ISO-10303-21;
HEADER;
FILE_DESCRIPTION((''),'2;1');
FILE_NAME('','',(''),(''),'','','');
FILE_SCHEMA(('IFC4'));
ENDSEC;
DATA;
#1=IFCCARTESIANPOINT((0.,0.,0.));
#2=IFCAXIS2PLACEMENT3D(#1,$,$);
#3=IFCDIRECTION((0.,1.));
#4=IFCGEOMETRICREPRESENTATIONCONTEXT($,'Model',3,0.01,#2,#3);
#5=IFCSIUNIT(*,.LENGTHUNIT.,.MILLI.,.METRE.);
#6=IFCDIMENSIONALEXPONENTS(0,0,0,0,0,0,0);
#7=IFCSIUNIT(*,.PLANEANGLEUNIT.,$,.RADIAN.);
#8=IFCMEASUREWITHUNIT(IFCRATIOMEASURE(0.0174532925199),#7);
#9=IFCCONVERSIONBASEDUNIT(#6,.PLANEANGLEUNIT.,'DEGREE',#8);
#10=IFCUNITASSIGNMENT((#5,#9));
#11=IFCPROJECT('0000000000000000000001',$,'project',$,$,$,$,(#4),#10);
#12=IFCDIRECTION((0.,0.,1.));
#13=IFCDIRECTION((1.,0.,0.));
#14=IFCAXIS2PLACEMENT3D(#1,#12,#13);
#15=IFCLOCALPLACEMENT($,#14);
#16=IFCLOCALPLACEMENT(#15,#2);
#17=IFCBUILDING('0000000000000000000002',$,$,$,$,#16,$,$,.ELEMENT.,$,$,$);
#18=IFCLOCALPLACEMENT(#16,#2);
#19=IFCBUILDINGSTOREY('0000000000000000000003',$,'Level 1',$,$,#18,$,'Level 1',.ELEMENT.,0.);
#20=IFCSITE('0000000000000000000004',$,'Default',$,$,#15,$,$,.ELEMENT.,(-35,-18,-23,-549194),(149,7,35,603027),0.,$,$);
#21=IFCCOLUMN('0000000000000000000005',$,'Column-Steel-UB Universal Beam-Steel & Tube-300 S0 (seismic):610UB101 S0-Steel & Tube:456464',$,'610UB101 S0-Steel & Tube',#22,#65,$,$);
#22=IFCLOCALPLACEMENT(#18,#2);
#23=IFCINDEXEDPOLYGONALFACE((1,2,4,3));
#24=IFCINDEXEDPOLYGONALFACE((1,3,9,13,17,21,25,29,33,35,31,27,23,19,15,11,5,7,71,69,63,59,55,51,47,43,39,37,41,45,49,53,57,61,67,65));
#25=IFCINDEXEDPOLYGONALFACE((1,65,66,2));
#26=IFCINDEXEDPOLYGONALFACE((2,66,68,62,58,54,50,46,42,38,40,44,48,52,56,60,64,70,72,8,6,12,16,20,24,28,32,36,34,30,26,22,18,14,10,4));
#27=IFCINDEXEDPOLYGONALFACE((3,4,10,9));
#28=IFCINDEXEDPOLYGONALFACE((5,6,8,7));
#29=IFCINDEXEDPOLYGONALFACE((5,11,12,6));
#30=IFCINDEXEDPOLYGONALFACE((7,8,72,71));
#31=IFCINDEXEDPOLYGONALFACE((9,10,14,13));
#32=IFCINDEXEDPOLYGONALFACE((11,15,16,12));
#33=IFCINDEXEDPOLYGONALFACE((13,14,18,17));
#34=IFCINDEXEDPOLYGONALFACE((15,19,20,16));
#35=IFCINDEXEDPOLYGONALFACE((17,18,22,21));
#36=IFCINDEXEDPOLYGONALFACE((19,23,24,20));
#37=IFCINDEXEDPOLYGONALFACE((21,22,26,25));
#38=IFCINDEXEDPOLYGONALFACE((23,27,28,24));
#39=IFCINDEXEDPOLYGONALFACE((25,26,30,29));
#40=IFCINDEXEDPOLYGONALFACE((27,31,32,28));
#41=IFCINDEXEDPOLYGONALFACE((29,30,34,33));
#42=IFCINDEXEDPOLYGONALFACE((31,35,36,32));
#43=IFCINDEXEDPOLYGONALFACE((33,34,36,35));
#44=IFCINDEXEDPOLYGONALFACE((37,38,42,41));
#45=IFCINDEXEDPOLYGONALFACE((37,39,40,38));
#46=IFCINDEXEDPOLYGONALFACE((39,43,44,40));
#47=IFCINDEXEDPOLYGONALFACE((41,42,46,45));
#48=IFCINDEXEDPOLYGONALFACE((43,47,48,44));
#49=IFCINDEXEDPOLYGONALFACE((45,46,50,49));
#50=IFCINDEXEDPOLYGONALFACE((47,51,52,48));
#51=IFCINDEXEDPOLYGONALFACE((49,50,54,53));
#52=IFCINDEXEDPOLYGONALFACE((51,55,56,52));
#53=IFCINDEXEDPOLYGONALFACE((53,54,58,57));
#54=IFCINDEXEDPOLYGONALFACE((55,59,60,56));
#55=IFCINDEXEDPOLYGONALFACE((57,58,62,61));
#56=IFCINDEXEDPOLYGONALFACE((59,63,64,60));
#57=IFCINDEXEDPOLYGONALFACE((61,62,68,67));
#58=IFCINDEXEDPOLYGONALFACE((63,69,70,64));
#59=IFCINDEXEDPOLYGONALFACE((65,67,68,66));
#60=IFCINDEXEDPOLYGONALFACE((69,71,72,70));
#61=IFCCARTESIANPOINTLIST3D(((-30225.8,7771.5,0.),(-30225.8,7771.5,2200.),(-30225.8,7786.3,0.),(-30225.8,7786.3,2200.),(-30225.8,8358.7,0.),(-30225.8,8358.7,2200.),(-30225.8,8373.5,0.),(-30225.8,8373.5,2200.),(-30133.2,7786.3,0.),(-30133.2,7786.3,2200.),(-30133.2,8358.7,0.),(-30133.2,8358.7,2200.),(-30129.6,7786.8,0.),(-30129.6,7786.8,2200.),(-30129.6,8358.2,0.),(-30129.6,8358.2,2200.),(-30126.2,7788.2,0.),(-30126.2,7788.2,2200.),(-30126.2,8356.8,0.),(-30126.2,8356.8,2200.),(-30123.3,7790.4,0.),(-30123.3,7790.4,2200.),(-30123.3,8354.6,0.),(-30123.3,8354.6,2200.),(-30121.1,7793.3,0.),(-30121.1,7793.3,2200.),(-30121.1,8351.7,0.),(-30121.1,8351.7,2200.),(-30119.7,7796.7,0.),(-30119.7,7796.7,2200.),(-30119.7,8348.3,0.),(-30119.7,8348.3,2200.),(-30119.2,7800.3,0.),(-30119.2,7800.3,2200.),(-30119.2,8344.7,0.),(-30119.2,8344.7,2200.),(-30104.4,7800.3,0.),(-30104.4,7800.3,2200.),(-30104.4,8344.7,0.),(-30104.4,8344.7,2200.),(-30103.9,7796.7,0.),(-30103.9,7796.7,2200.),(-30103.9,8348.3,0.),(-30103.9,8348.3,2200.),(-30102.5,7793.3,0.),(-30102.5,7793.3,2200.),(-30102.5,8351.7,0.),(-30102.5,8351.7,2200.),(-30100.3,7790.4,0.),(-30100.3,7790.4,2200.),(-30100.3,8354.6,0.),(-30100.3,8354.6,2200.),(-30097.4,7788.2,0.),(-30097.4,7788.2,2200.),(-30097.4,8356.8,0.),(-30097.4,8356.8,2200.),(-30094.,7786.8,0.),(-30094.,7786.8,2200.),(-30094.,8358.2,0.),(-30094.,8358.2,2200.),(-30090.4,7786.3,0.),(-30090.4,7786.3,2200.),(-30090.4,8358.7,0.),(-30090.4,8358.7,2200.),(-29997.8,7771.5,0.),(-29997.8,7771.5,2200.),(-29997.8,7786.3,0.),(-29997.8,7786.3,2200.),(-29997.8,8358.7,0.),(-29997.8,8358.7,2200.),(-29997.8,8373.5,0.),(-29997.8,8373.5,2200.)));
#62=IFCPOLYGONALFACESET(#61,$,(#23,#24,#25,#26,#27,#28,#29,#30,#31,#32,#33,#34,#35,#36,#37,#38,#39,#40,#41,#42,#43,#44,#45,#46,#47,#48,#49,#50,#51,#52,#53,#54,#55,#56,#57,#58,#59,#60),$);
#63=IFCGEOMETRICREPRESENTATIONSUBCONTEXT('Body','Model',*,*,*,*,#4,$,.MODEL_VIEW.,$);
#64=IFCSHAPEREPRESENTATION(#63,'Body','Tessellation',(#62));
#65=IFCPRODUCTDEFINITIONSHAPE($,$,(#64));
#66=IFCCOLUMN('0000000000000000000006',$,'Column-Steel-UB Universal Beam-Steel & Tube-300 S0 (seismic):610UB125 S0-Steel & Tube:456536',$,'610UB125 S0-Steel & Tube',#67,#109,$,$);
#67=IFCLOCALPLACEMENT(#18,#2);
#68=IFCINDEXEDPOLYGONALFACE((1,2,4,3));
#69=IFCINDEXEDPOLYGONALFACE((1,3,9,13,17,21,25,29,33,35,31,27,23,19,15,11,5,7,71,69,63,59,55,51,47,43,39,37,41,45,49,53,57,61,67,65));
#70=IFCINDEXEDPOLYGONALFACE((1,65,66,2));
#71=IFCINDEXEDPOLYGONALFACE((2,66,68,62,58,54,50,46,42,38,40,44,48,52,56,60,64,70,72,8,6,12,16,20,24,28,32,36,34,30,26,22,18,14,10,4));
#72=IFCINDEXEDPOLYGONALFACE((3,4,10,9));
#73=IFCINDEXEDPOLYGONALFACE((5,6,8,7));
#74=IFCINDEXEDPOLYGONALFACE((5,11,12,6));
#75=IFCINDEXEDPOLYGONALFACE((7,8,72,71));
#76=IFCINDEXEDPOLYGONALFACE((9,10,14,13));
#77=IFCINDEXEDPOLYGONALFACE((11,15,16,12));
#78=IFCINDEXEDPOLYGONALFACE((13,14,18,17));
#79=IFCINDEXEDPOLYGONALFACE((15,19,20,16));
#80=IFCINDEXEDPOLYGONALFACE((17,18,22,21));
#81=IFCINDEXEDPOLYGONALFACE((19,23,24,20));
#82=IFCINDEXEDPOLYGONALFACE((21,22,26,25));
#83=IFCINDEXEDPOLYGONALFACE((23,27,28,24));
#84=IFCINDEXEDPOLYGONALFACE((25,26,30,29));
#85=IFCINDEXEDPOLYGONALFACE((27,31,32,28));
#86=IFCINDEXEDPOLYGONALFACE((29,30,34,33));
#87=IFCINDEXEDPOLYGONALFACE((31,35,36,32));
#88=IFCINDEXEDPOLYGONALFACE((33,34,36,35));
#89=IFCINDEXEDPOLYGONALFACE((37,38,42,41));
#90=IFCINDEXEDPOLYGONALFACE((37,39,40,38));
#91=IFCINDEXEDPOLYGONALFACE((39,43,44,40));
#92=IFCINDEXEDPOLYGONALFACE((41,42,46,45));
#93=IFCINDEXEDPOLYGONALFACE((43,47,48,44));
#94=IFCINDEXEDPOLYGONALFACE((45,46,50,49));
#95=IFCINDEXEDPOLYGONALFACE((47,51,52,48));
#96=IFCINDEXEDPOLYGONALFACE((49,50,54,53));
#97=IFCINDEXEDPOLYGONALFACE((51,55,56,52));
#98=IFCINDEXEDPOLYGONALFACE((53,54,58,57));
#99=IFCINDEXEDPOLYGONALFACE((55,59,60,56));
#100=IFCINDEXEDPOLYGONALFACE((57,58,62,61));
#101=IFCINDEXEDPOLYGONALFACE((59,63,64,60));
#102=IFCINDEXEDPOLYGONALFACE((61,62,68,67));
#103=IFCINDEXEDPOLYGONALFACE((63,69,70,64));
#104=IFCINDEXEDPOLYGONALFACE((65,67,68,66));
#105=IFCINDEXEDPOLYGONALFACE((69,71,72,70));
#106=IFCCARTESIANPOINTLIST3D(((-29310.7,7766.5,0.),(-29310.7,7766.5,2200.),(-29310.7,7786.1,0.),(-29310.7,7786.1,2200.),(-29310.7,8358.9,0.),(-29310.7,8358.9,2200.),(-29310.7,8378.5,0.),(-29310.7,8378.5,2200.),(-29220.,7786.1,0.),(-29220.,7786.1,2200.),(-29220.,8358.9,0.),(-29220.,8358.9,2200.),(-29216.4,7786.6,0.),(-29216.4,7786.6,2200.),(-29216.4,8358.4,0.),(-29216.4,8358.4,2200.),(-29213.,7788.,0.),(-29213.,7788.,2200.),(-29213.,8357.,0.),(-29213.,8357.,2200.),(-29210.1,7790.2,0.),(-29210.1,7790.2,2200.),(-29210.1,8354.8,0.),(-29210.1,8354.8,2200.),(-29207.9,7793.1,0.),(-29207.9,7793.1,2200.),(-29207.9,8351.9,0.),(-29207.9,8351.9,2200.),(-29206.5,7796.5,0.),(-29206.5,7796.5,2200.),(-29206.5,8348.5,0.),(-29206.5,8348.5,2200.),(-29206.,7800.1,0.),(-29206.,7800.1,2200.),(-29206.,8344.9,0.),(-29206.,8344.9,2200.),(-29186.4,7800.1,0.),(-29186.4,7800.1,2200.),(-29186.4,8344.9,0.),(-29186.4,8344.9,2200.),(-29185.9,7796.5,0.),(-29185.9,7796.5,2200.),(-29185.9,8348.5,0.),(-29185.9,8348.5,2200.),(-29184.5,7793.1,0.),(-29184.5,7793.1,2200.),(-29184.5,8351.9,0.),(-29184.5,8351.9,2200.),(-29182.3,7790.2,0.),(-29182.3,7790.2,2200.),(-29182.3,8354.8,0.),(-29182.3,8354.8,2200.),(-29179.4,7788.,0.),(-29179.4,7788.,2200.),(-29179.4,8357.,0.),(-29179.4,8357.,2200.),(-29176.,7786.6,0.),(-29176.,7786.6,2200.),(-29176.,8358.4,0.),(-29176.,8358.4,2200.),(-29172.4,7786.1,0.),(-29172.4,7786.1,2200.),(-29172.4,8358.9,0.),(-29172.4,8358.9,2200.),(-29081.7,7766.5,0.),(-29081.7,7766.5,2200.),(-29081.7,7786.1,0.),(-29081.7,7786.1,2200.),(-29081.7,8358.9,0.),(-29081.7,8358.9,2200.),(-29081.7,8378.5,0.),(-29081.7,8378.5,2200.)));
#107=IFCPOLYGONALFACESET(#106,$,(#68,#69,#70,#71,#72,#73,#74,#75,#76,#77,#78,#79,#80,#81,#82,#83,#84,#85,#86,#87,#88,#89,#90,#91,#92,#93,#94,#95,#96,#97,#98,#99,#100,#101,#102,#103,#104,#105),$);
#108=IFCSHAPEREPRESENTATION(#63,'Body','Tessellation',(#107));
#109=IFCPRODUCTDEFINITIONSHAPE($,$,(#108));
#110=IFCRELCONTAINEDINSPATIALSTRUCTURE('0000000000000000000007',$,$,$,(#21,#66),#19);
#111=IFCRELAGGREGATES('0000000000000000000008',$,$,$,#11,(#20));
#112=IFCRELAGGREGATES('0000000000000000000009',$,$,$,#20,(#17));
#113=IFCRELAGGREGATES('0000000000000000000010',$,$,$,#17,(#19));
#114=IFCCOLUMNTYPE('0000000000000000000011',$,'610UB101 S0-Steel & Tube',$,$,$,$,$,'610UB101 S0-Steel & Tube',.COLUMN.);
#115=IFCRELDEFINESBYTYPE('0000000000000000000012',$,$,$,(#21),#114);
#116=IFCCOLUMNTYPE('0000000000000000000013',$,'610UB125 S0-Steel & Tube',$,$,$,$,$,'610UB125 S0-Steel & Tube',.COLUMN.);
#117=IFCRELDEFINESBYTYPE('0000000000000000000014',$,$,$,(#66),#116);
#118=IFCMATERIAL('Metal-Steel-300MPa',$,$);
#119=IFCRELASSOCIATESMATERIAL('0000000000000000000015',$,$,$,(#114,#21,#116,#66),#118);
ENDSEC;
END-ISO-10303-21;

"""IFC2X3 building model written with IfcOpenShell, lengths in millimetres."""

from ifc_helpers import new_model, entity, si_unit, converted_unit, direction, frame, frame_2d, origin, origin_with_axes, place, context, subcontext, project, spatial, polyline, circle_curve, parameter, trimmed, segment, composite_curve, outline, extrude, source, transform, mapped, material, type_object, type_shapes, element, save


model = new_model("IFC2X3")

# Units and contexts
model_context = context("Model", 3, precision=0.01, world=origin(), true_north=direction((0.0, 1.0)))
body_context = subcontext(model_context, "Body", "Model", "MODEL_VIEW")
ifc_project = project(units=[si_unit("LENGTHUNIT", "METRE", prefix="MILLI"), converted_unit("PLANEANGLEUNIT", "DEGREE", entity("IfcRatioMeasure", 0.0174532925199), si_unit("PLANEANGLEUNIT", "RADIAN"), dimensions=[0, 0, 0, 0, 0, 0, 0])], contexts=[model_context])

# Site, building, storey
site_placement = place(None, origin_with_axes())
site = spatial("IfcSite", under=ifc_project, at=site_placement, Name="Default", CompositionType="ELEMENT", RefLatitude=(-35, -18, -23, -549194), RefLongitude=(149, 7, 35, 603027), RefElevation=0.0)
building_placement = place(site_placement, origin())
building = spatial("IfcBuilding", under=site, at=building_placement, CompositionType="ELEMENT")
storey_placement = place(building_placement, origin())
storey = spatial("IfcBuildingStorey", under=building, at=storey_placement, Name="Level 1", LongName="Level 1", CompositionType="ELEMENT", Elevation=0.0)

# Columns
ifc_material = material(Name="Metal-Steel-300MPa")
column_type_1 = type_object("IfcColumnType", Name="610UB101 S0-Steel & Tube", ElementType="610UB101 S0-Steel & Tube", PredefinedType="COLUMN", material=ifc_material)
shared_shape_1 = source(origin(), body_context, "Body", "SweptSolid", [
    extrude(outline(composite_curve([segment(polyline([(286.2, -114.0), (301.0, -114.0)]), True, "CONTINUOUS"), segment(polyline([(301.0, -114.0), (301.0, 114.0)]), True, "CONTINUOUS"), segment(polyline([(301.0, 114.0), (286.2, 114.0)]), True, "CONTINUOUS"), segment(polyline([(286.2, 114.0), (286.2, 21.4)]), True, "CONTINUOUS"), segment(trimmed(circle_curve(frame_2d((272.2, 21.4), x_axis=(1.0, 0.0)), 14.0), [parameter(270.0)], [parameter(0.0)], True, "PARAMETER"), False, "CONTINUOUS"), segment(polyline([(272.2, 7.4), (-272.2, 7.4)]), True, "CONTINUOUS"), segment(trimmed(circle_curve(frame_2d((-272.2, 21.4), x_axis=(0.0, -1.0)), 14.0), [parameter(270.0)], [parameter(0.0)], True, "PARAMETER"), False, "CONTINUOUS"), segment(polyline([(-286.2, 21.4), (-286.2, 114.0)]), True, "CONTINUOUS"), segment(polyline([(-286.2, 114.0), (-301.0, 114.0)]), True, "CONTINUOUS"), segment(polyline([(-301.0, 114.0), (-301.0, -114.0)]), True, "CONTINUOUS"), segment(polyline([(-301.0, -114.0), (-286.2, -114.0)]), True, "CONTINUOUS"), segment(polyline([(-286.2, -114.0), (-286.2, -21.4)]), True, "CONTINUOUS"), segment(trimmed(circle_curve(frame_2d((-272.2, -21.4), x_axis=(-1.0, 0.0)), 14.0), [parameter(270.0)], [parameter(0.0)], True, "PARAMETER"), False, "CONTINUOUS"), segment(polyline([(-272.2, -7.4), (272.2, -7.4)]), True, "CONTINUOUS"), segment(trimmed(circle_curve(frame_2d((272.2, -21.4), x_axis=(0.0, 1.0)), 14.0), [parameter(270.0)], [parameter(0.0)], True, "PARAMETER"), False, "CONTINUOUS"), segment(polyline([(286.2, -21.4), (286.2, -114.0)]), True, "CONTINUOUS")], self_intersect=False)), frame((0.0, 0.0, 0.0), z_axis=(0.0, 0.0, 1.0), x_axis=(0.0, -1.0, 0.0)), (0.0, 0.0, 1.0), 2200.0),
])
type_shapes(column_type_1, [shared_shape_1])
column_1_placement = place(storey_placement, frame((-30111.8, 8072.5, 0.0)))
element("IfcColumn", 1, at=column_1_placement, inside=storey, type_object=column_type_1, material=ifc_material, Name="Column-Steel-UB Universal Beam-Steel & Tube-300 S0 (seismic):610UB101 S0-Steel & Tube:456464", ObjectType="610UB101 S0-Steel & Tube", context=body_context, shape_type="MappedRepresentation", body=[
    mapped(shared_shape_1, transform((0.0, 0.0, 0.0), scale=1.0)),
])
column_type_2 = type_object("IfcColumnType", Name="610UB125 S0-Steel & Tube", ElementType="610UB125 S0-Steel & Tube", PredefinedType="COLUMN", material=ifc_material)
shared_shape_2 = source(origin(), body_context, "Body", "SweptSolid", [
    extrude(outline(composite_curve([segment(polyline([(286.4, -114.5), (306.0, -114.5)]), True, "CONTINUOUS"), segment(polyline([(306.0, -114.5), (306.0, 114.5)]), True, "CONTINUOUS"), segment(polyline([(306.0, 114.5), (286.4, 114.5)]), True, "CONTINUOUS"), segment(polyline([(286.4, 114.5), (286.4, 23.8)]), True, "CONTINUOUS"), segment(trimmed(circle_curve(frame_2d((272.4, 23.8), x_axis=(1.0, 0.0)), 14.0), [parameter(270.0)], [parameter(0.0)], True, "PARAMETER"), False, "CONTINUOUS"), segment(polyline([(272.4, 9.8), (-272.4, 9.8)]), True, "CONTINUOUS"), segment(trimmed(circle_curve(frame_2d((-272.4, 23.8), x_axis=(0.0, -1.0)), 14.0), [parameter(270.0)], [parameter(0.0)], True, "PARAMETER"), False, "CONTINUOUS"), segment(polyline([(-286.4, 23.8), (-286.4, 114.5)]), True, "CONTINUOUS"), segment(polyline([(-286.4, 114.5), (-306.0, 114.5)]), True, "CONTINUOUS"), segment(polyline([(-306.0, 114.5), (-306.0, -114.5)]), True, "CONTINUOUS"), segment(polyline([(-306.0, -114.5), (-286.4, -114.5)]), True, "CONTINUOUS"), segment(polyline([(-286.4, -114.5), (-286.4, -23.8)]), True, "CONTINUOUS"), segment(trimmed(circle_curve(frame_2d((-272.4, -23.8), x_axis=(-1.0, 0.0)), 14.0), [parameter(270.0)], [parameter(0.0)], True, "PARAMETER"), False, "CONTINUOUS"), segment(polyline([(-272.4, -9.8), (272.4, -9.8)]), True, "CONTINUOUS"), segment(trimmed(circle_curve(frame_2d((272.4, -23.8), x_axis=(0.0, 1.0)), 14.0), [parameter(270.0)], [parameter(0.0)], True, "PARAMETER"), False, "CONTINUOUS"), segment(polyline([(286.4, -23.8), (286.4, -114.5)]), True, "CONTINUOUS")], self_intersect=False)), frame((0.0, 0.0, 0.0), z_axis=(0.0, 0.0, 1.0), x_axis=(0.0, -1.0, 0.0)), (0.0, 0.0, 1.0), 2200.0),
])
type_shapes(column_type_2, [shared_shape_2])
column_2_placement = place(storey_placement, frame((-29196.2, 8072.5, 0.0)))
element("IfcColumn", 2, at=column_2_placement, inside=storey, type_object=column_type_2, material=ifc_material, Name="Column-Steel-UB Universal Beam-Steel & Tube-300 S0 (seismic):610UB125 S0-Steel & Tube:456536", ObjectType="610UB125 S0-Steel & Tube", context=body_context, shape_type="MappedRepresentation", body=[
    mapped(shared_shape_2, transform((0.0, 0.0, 0.0), scale=1.0)),
])

save(model, "model.ifc")
